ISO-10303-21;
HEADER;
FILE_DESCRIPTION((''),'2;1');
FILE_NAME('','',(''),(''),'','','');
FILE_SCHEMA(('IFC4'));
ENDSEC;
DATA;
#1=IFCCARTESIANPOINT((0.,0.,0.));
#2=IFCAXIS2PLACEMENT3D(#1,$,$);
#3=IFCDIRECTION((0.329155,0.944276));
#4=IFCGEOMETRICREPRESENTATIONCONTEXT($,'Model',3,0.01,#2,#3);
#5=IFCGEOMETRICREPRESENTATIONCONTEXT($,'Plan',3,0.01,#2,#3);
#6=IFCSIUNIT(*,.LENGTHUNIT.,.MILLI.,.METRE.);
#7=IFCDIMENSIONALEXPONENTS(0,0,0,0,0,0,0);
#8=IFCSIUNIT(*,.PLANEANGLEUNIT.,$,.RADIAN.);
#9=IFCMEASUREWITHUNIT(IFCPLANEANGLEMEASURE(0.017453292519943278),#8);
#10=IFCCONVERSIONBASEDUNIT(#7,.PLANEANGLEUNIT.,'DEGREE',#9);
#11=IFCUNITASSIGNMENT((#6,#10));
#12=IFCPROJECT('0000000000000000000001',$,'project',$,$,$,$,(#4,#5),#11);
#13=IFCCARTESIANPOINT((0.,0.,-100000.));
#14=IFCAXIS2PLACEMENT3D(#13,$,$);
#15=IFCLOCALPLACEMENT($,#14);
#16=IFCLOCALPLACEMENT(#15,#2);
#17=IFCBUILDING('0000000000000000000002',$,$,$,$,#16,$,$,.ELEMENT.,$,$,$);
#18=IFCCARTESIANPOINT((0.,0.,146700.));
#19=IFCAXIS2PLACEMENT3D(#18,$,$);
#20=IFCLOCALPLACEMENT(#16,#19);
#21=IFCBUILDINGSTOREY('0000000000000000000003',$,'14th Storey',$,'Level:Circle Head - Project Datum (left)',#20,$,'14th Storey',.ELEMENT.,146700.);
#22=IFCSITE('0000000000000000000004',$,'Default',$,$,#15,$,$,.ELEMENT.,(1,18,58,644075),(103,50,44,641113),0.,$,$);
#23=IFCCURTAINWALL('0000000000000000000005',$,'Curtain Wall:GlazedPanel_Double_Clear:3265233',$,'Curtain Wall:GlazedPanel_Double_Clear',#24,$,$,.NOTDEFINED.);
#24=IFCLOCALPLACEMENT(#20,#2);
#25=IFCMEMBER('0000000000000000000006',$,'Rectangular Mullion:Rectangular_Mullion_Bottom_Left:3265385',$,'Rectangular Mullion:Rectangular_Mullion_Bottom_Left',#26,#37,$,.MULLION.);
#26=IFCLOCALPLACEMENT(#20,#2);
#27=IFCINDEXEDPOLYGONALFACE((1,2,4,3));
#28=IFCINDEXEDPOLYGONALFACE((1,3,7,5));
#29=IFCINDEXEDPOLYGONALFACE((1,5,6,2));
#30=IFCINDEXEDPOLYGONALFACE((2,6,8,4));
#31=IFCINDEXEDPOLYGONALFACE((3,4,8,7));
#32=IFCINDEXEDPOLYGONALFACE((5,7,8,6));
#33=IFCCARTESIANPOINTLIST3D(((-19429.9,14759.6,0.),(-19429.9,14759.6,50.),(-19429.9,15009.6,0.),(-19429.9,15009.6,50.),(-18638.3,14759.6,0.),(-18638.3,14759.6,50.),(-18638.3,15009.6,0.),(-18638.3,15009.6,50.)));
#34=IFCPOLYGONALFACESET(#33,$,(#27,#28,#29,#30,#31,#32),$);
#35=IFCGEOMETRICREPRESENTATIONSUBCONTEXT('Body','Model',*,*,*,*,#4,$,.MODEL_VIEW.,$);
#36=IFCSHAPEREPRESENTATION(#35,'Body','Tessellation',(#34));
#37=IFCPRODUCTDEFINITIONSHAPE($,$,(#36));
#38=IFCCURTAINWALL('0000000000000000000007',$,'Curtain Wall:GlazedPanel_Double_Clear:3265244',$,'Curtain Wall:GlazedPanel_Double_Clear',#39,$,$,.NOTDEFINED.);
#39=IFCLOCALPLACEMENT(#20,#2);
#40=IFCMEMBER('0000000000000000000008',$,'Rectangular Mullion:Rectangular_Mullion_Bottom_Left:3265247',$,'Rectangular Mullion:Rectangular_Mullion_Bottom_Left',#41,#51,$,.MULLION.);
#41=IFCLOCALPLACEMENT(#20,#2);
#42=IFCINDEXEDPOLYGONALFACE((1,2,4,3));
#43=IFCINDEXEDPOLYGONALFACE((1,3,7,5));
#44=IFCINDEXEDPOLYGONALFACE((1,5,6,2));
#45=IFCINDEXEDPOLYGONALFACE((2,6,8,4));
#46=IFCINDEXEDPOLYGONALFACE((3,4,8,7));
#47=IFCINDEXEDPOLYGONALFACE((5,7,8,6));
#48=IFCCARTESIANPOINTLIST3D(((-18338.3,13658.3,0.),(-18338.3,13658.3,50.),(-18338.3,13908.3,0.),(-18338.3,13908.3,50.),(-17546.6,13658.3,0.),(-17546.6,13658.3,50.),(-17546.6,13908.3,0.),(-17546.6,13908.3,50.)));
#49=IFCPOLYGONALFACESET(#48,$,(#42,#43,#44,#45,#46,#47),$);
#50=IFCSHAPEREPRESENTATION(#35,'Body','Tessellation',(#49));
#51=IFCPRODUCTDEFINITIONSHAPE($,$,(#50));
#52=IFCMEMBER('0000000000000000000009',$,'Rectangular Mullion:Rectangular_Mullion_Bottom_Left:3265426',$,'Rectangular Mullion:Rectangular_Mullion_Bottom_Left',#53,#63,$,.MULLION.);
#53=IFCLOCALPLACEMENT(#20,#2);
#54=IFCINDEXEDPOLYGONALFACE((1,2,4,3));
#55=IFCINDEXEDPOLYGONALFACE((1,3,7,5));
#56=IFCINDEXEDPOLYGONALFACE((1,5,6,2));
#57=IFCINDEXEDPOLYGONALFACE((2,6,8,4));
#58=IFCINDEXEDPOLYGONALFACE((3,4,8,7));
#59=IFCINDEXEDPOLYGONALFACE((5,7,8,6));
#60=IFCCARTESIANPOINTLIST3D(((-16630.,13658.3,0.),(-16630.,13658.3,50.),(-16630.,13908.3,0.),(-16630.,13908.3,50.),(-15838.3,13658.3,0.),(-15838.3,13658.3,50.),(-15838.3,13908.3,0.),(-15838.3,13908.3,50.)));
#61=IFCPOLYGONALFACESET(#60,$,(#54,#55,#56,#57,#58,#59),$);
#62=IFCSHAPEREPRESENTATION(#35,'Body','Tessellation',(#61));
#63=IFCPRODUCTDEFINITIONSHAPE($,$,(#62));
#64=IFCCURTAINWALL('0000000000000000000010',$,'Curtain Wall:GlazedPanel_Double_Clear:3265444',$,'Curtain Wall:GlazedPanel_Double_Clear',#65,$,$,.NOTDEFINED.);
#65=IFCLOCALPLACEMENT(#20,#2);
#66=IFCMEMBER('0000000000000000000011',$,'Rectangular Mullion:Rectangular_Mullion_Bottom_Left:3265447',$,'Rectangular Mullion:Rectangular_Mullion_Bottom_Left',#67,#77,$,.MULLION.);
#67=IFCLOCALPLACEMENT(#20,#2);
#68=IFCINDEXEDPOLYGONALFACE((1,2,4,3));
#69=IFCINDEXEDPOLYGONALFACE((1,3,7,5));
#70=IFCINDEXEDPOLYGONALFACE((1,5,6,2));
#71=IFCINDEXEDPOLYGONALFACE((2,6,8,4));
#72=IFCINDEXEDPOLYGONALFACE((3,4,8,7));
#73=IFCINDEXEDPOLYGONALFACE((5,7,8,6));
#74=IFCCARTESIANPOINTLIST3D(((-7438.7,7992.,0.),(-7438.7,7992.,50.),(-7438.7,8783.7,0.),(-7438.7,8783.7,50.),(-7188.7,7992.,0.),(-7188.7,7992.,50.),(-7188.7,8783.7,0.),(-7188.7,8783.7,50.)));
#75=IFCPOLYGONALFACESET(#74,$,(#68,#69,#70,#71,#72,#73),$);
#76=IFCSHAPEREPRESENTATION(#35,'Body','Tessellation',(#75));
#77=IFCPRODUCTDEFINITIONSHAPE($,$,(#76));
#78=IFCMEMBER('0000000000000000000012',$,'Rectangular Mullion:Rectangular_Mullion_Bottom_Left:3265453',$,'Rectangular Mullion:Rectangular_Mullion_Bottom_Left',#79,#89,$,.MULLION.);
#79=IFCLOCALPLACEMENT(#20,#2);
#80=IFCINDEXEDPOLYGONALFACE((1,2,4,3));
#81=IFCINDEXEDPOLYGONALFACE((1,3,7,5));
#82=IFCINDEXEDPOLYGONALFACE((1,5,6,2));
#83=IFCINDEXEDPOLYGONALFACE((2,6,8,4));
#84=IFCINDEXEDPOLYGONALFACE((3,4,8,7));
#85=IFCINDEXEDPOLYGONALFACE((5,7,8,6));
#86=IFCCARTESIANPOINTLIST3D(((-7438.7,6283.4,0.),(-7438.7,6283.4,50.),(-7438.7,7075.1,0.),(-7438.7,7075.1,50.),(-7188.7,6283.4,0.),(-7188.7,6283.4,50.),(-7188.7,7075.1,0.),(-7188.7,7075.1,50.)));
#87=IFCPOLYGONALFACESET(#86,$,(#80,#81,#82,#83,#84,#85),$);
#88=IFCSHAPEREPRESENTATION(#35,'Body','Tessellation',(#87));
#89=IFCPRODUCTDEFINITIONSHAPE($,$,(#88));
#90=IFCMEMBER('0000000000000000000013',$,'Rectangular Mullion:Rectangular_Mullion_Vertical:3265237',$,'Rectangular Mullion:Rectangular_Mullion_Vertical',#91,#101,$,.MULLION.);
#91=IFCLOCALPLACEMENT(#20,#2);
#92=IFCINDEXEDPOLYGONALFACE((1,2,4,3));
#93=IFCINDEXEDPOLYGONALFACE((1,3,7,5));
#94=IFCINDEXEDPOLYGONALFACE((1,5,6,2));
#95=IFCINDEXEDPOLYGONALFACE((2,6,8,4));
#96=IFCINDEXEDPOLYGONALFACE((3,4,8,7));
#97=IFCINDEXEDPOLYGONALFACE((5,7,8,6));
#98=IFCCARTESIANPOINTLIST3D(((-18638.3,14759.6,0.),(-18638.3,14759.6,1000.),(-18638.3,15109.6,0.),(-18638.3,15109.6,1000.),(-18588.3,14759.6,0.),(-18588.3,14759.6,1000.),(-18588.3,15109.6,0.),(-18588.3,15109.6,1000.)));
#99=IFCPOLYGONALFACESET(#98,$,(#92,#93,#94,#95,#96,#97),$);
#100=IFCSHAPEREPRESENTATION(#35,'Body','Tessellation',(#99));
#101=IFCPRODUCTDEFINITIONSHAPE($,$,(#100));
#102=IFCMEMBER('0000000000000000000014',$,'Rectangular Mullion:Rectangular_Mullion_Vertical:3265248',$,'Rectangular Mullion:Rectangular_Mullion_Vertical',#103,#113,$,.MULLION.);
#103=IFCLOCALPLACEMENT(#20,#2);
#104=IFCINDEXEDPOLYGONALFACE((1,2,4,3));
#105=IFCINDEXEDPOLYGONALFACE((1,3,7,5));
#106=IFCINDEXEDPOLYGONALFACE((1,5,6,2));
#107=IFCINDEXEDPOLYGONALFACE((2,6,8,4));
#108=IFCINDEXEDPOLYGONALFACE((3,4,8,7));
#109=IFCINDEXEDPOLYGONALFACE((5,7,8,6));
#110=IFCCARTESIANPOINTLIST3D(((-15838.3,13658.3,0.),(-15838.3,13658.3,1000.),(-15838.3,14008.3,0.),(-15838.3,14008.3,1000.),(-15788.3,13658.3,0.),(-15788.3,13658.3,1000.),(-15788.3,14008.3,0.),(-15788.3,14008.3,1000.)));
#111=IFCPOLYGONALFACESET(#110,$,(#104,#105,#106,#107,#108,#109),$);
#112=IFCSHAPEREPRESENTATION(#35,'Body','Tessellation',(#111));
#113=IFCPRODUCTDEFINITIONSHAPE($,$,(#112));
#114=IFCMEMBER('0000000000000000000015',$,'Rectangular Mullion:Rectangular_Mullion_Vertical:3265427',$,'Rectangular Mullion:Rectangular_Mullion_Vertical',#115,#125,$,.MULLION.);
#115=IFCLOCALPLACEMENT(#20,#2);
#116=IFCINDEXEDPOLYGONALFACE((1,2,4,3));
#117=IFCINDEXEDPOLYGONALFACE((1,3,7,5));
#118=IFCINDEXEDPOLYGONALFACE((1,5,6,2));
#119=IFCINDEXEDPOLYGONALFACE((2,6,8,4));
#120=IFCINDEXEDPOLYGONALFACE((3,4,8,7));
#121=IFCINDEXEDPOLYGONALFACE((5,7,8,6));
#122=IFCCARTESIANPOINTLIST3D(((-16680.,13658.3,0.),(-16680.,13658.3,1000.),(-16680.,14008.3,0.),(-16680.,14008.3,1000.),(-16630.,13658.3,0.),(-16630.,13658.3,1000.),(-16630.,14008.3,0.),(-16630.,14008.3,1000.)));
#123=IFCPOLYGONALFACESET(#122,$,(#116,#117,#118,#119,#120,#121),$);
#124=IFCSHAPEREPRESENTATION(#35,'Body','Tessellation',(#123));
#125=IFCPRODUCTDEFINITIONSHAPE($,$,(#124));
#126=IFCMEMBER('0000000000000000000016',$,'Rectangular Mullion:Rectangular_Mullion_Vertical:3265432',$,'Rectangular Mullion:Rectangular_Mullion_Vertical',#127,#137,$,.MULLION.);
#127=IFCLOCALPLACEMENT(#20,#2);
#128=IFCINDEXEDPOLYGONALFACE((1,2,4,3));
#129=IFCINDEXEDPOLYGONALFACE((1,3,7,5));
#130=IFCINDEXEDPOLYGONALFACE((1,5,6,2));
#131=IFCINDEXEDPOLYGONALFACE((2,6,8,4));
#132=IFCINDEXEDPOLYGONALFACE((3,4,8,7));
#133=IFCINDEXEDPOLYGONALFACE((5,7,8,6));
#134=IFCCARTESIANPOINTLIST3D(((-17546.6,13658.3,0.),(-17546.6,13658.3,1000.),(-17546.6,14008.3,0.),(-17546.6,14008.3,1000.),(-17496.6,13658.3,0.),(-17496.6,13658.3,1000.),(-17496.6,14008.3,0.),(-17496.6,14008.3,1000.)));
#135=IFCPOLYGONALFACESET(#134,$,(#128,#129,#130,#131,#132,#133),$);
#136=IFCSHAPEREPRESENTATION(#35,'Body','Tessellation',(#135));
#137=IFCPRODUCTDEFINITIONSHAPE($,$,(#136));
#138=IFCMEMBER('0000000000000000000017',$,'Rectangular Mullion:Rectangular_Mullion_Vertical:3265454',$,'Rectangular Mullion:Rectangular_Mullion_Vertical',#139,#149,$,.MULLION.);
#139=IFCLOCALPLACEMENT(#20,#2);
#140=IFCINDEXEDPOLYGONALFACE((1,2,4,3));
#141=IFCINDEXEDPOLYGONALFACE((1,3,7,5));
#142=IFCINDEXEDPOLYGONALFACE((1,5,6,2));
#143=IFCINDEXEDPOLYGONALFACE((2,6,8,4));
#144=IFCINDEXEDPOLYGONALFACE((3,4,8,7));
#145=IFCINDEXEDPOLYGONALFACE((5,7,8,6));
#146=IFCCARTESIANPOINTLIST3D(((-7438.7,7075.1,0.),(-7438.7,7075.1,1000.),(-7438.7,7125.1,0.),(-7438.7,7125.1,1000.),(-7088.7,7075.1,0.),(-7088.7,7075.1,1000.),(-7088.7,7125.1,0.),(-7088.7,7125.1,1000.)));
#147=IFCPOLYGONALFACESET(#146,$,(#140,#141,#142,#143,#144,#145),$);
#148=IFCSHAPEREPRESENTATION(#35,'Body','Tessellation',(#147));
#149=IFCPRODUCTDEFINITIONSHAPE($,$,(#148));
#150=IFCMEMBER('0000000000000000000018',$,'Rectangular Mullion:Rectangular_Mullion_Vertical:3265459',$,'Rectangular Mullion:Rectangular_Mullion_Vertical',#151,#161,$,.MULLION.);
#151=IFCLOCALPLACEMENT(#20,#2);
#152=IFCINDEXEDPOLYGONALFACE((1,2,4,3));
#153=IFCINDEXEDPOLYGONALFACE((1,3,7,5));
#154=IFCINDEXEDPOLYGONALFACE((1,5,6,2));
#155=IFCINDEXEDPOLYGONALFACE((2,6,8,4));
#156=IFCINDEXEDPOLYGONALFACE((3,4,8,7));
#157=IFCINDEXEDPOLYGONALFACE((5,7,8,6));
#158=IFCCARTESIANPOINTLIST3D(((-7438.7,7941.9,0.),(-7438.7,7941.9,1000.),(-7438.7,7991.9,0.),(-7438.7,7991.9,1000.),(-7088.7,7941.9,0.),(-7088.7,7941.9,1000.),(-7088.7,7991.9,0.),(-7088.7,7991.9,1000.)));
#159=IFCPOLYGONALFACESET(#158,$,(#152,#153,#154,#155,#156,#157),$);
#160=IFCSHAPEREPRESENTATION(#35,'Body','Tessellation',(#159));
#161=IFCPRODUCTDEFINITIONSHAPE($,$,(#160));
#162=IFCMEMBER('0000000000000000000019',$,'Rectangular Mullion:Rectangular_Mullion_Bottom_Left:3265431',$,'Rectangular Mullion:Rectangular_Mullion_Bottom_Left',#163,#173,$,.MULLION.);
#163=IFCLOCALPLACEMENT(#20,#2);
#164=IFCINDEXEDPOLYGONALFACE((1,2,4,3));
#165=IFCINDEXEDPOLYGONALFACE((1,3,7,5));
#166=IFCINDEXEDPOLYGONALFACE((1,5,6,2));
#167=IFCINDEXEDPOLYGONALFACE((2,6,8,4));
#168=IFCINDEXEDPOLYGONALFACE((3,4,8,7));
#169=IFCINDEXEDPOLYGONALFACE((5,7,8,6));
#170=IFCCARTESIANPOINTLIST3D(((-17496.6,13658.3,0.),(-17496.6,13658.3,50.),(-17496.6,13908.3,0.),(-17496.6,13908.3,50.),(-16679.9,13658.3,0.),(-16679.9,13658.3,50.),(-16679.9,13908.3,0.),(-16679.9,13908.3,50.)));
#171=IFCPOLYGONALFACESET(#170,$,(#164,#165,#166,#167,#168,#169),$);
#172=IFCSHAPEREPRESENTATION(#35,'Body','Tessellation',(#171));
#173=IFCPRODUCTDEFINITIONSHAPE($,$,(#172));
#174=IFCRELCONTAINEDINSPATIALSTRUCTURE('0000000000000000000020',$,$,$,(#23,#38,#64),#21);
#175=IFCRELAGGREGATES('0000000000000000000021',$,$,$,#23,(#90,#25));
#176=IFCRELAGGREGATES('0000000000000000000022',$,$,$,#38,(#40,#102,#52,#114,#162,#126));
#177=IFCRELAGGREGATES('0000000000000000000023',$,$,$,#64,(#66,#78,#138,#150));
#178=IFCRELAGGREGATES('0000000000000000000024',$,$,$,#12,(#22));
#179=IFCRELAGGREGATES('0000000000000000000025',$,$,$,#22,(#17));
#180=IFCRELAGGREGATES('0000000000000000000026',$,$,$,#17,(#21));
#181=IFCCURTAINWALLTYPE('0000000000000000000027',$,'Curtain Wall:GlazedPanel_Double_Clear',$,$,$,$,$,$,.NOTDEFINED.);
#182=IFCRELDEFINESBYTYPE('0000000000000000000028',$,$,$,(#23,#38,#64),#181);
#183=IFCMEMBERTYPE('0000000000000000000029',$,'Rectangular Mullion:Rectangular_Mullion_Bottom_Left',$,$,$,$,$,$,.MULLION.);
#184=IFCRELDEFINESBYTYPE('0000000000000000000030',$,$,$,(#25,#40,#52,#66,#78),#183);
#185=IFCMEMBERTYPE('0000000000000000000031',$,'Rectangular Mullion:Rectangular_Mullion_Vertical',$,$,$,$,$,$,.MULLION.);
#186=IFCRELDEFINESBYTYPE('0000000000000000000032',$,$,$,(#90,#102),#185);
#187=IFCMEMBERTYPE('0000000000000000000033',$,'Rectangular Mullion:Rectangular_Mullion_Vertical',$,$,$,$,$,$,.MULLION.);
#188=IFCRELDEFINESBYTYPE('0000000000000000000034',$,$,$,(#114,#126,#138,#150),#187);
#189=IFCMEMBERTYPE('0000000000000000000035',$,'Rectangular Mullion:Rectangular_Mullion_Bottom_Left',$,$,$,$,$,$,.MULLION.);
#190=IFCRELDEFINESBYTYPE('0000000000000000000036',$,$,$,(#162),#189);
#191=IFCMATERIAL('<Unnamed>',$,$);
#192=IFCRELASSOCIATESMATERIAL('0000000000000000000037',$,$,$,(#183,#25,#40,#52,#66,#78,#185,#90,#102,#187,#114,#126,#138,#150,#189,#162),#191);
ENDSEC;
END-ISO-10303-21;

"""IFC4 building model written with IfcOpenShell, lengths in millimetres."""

from ifc_helpers import new_model, entity, si_unit, converted_unit, direction, frame, origin, place, context, subcontext, project, spatial, indexed_curve, outline, extrude, source, transform, mapped, material, type_object, type_shapes, element, aggregate, save


model = new_model("IFC4")

# Units and contexts
model_context = context("Model", 3, precision=0.01, world=origin(), true_north=direction((0.329155, 0.944276)))
plan_context = context("Plan", 3, precision=0.01, world=origin(), true_north=direction((0.329155, 0.944276)))
body_context = subcontext(model_context, "Body", "Model", "MODEL_VIEW")
ifc_project = project(units=[si_unit("LENGTHUNIT", "METRE", prefix="MILLI"), converted_unit("PLANEANGLEUNIT", "DEGREE", entity("IfcPlaneAngleMeasure", 0.017453292519943278), si_unit("PLANEANGLEUNIT", "RADIAN"), dimensions=[0, 0, 0, 0, 0, 0, 0])], contexts=[model_context, plan_context])

# Site, building, storey
site_placement = place(None, frame((0.0, 0.0, -100000.0)))
site = spatial("IfcSite", under=ifc_project, at=site_placement, Name="Default", CompositionType="ELEMENT", RefLatitude=(1, 18, 58, 644075), RefLongitude=(103, 50, 44, 641113), RefElevation=0.0)
building_placement = place(site_placement, origin())
building = spatial("IfcBuilding", under=site, at=building_placement, CompositionType="ELEMENT")
storey_placement = place(building_placement, frame((0.0, 0.0, 146700.0)))
storey = spatial("IfcBuildingStorey", under=building, at=storey_placement, Name="14th Storey", ObjectType="Level:Circle Head - Project Datum (left)", LongName="14th Storey", CompositionType="ELEMENT", Elevation=146700.0)

# Curtain wall, member
curtain_wall_type = type_object("IfcCurtainWallType", Name="Curtain Wall:GlazedPanel_Double_Clear", PredefinedType="NOTDEFINED")
curtain_wall_1_placement = place(storey_placement, frame((0.0, 0.0, -146700.0)))
curtain_wall_1 = element("IfcCurtainWall", 1, at=curtain_wall_1_placement, inside=storey, type_object=curtain_wall_type, Name="Curtain Wall:GlazedPanel_Double_Clear:3265233", ObjectType="Curtain Wall:GlazedPanel_Double_Clear", PredefinedType="NOTDEFINED")
ifc_material_1 = material(Name="<Unnamed>")
member_type_1 = type_object("IfcMemberType", Name="Rectangular Mullion:Rectangular_Mullion_Bottom_Left", PredefinedType="MULLION", material=ifc_material_1)
shared_shape_1 = source(origin(), body_context, "Body", "SweptSolid", [
    extrude(outline(indexed_curve([(-25.0, -125.0), (25.0, -125.0), (25.0, 125.0), (-25.0, 125.0), (-25.0, -125.0)], self_intersect=False)), frame((-25.0, 0.0, -791.7), z_axis=(0.0, 0.0, 1.0), x_axis=(-1.0, 0.0, 0.0)), (0.0, 0.0, 1.0), 791.7),
])
type_shapes(member_type_1, [shared_shape_1])
member_1_placement = place(curtain_wall_1_placement, frame((-19429.9, 14884.6, 146700.0), z_axis=(-1.0, 0.0, 0.0), x_axis=(0.0, 0.0, -1.0)))
member_1 = element("IfcMember", 2, at=member_1_placement, type_object=member_type_1, material=ifc_material_1, Name="Rectangular Mullion:Rectangular_Mullion_Bottom_Left:3265385", ObjectType="Rectangular Mullion:Rectangular_Mullion_Bottom_Left", PredefinedType="MULLION", context=body_context, shape_type="MappedRepresentation", body=[
    mapped(shared_shape_1, transform((0.0, 0.0, 0.0), scale=1.0)),
])

# Curtain walls, members
curtain_wall_2_placement = place(storey_placement, frame((0.0, 0.0, -146700.0)))
curtain_wall_2 = element("IfcCurtainWall", 3, at=curtain_wall_2_placement, inside=storey, type_object=curtain_wall_type, Name="Curtain Wall:GlazedPanel_Double_Clear:3265244", ObjectType="Curtain Wall:GlazedPanel_Double_Clear", PredefinedType="NOTDEFINED")
member_2_placement = place(curtain_wall_2_placement, frame((-18338.3, 13783.3, 146700.0), z_axis=(-1.0, 0.0, 0.0), x_axis=(0.0, 0.0, -1.0)))
member_2 = element("IfcMember", 4, at=member_2_placement, type_object=member_type_1, material=ifc_material_1, Name="Rectangular Mullion:Rectangular_Mullion_Bottom_Left:3265247", ObjectType="Rectangular Mullion:Rectangular_Mullion_Bottom_Left", PredefinedType="MULLION", context=body_context, shape_type="MappedRepresentation", body=[
    mapped(shared_shape_1, transform((0.0, 0.0, 0.0), scale=1.0)),
])
member_3_placement = place(curtain_wall_2_placement, frame((-16630.0, 13783.3, 146700.0), z_axis=(-1.0, 0.0, 0.0), x_axis=(0.0, 0.0, -1.0)))
member_3 = element("IfcMember", 5, at=member_3_placement, type_object=member_type_1, material=ifc_material_1, Name="Rectangular Mullion:Rectangular_Mullion_Bottom_Left:3265426", ObjectType="Rectangular Mullion:Rectangular_Mullion_Bottom_Left", PredefinedType="MULLION", context=body_context, shape_type="MappedRepresentation", body=[
    mapped(shared_shape_1, transform((0.0, 0.0, 0.0), scale=1.0)),
])
curtain_wall_3_placement = place(storey_placement, frame((0.0, 0.0, -146700.0)))
curtain_wall_3 = element("IfcCurtainWall", 6, at=curtain_wall_3_placement, inside=storey, type_object=curtain_wall_type, Name="Curtain Wall:GlazedPanel_Double_Clear:3265444", ObjectType="Curtain Wall:GlazedPanel_Double_Clear", PredefinedType="NOTDEFINED")
member_4_placement = place(curtain_wall_3_placement, frame((-7313.7, 8783.7, 146700.0), z_axis=(0.0, 1.0, 0.0), x_axis=(0.0, 0.0, -1.0)))
member_4 = element("IfcMember", 7, at=member_4_placement, type_object=member_type_1, material=ifc_material_1, Name="Rectangular Mullion:Rectangular_Mullion_Bottom_Left:3265447", ObjectType="Rectangular Mullion:Rectangular_Mullion_Bottom_Left", PredefinedType="MULLION", context=body_context, shape_type="MappedRepresentation", body=[
    mapped(shared_shape_1, transform((0.0, 0.0, 0.0), scale=1.0)),
])
member_5_placement = place(curtain_wall_3_placement, frame((-7313.7, 7075.1, 146700.0), z_axis=(0.0, 1.0, 0.0), x_axis=(0.0, 0.0, -1.0)))
member_5 = element("IfcMember", 8, at=member_5_placement, type_object=member_type_1, material=ifc_material_1, Name="Rectangular Mullion:Rectangular_Mullion_Bottom_Left:3265453", ObjectType="Rectangular Mullion:Rectangular_Mullion_Bottom_Left", PredefinedType="MULLION", context=body_context, shape_type="MappedRepresentation", body=[
    mapped(shared_shape_1, transform((0.0, 0.0, 0.0), scale=1.0)),
])

# Members
member_type_2 = type_object("IfcMemberType", Name="Rectangular Mullion:Rectangular_Mullion_Vertical", PredefinedType="MULLION", material=ifc_material_1)
shared_shape_2 = source(origin(), body_context, "Body", "SweptSolid", [
    extrude(outline(indexed_curve([(-25.0, -175.0), (25.0, -175.0), (25.0, 175.0), (-25.0, 175.0), (-25.0, -175.0)], self_intersect=False)), frame((-25.0, -50.0, -1000.0), z_axis=(0.0, 0.0, 1.0), x_axis=(-1.0, 0.0, 0.0)), (0.0, 0.0, 1.0), 1000.0),
])
type_shapes(member_type_2, [shared_shape_2])
member_6_placement = place(curtain_wall_1_placement, frame((-18588.3, 14884.6, 146700.0), z_axis=(0.0, 0.0, -1.0), x_axis=(1.0, 0.0, 0.0)))
member_6 = element("IfcMember", 9, at=member_6_placement, type_object=member_type_2, material=ifc_material_1, Name="Rectangular Mullion:Rectangular_Mullion_Vertical:3265237", ObjectType="Rectangular Mullion:Rectangular_Mullion_Vertical", PredefinedType="MULLION", context=body_context, shape_type="MappedRepresentation", body=[
    mapped(shared_shape_2, transform((0.0, 0.0, 0.0), scale=1.0)),
])
aggregate(curtain_wall_1, [member_6, member_1])
member_7_placement = place(curtain_wall_2_placement, frame((-15788.3, 13783.3, 146700.0), z_axis=(0.0, 0.0, -1.0), x_axis=(1.0, 0.0, 0.0)))
member_7 = element("IfcMember", 10, at=member_7_placement, type_object=member_type_2, material=ifc_material_1, Name="Rectangular Mullion:Rectangular_Mullion_Vertical:3265248", ObjectType="Rectangular Mullion:Rectangular_Mullion_Vertical", PredefinedType="MULLION", context=body_context, shape_type="MappedRepresentation", body=[
    mapped(shared_shape_2, transform((0.0, 0.0, 0.0), scale=1.0)),
])
member_type_3 = type_object("IfcMemberType", Name="Rectangular Mullion:Rectangular_Mullion_Vertical", PredefinedType="MULLION", material=ifc_material_1)
shared_shape_3 = source(origin(), body_context, "Body", "SweptSolid", [
    extrude(outline(indexed_curve([(-25.0, -175.0), (25.0, -175.0), (25.0, 175.0), (-25.0, 175.0), (-25.0, -175.0)], self_intersect=False)), frame((0.0, -50.0, -1000.0), z_axis=(0.0, 0.0, 1.0), x_axis=(-1.0, 0.0, 0.0)), (0.0, 0.0, 1.0), 1000.0),
])
type_shapes(member_type_3, [shared_shape_3])
member_8_placement = place(curtain_wall_2_placement, frame((-16655.0, 13783.3, 146700.0), z_axis=(0.0, 0.0, -1.0), x_axis=(1.0, 0.0, 0.0)))
member_8 = element("IfcMember", 11, at=member_8_placement, type_object=member_type_3, material=ifc_material_1, Name="Rectangular Mullion:Rectangular_Mullion_Vertical:3265427", ObjectType="Rectangular Mullion:Rectangular_Mullion_Vertical", PredefinedType="MULLION", context=body_context, shape_type="MappedRepresentation", body=[
    mapped(shared_shape_3, transform((0.0, 0.0, 0.0), scale=1.0)),
])
member_9_placement = place(curtain_wall_2_placement, frame((-17521.6, 13783.3, 146700.0), z_axis=(0.0, 0.0, -1.0), x_axis=(1.0, 0.0, 0.0)))
member_9 = element("IfcMember", 12, at=member_9_placement, type_object=member_type_3, material=ifc_material_1, Name="Rectangular Mullion:Rectangular_Mullion_Vertical:3265432", ObjectType="Rectangular Mullion:Rectangular_Mullion_Vertical", PredefinedType="MULLION", context=body_context, shape_type="MappedRepresentation", body=[
    mapped(shared_shape_3, transform((0.0, 0.0, 0.0), scale=1.0)),
])
member_10_placement = place(curtain_wall_3_placement, frame((-7313.7, 7100.1, 146700.0), z_axis=(0.0, 0.0, -1.0), x_axis=(0.0, -1.0, 0.0)))
member_10 = element("IfcMember", 13, at=member_10_placement, type_object=member_type_3, material=ifc_material_1, Name="Rectangular Mullion:Rectangular_Mullion_Vertical:3265454", ObjectType="Rectangular Mullion:Rectangular_Mullion_Vertical", PredefinedType="MULLION", context=body_context, shape_type="MappedRepresentation", body=[
    mapped(shared_shape_3, transform((0.0, 0.0, 0.0), scale=1.0)),
])
member_11_placement = place(curtain_wall_3_placement, frame((-7313.7, 7966.9, 146700.0), z_axis=(0.0, 0.0, -1.0), x_axis=(0.0, -1.0, 0.0)))
member_11 = element("IfcMember", 14, at=member_11_placement, type_object=member_type_3, material=ifc_material_1, Name="Rectangular Mullion:Rectangular_Mullion_Vertical:3265459", ObjectType="Rectangular Mullion:Rectangular_Mullion_Vertical", PredefinedType="MULLION", context=body_context, shape_type="MappedRepresentation", body=[
    mapped(shared_shape_3, transform((0.0, 0.0, 0.0), scale=1.0)),
])
member_type_4 = type_object("IfcMemberType", Name="Rectangular Mullion:Rectangular_Mullion_Bottom_Left", PredefinedType="MULLION", material=ifc_material_1)
shared_shape_4 = source(origin(), body_context, "Body", "SweptSolid", [
    extrude(outline(indexed_curve([(-25.0, -125.0), (25.0, -125.0), (25.0, 125.0), (-25.0, 125.0), (-25.0, -125.0)], self_intersect=False)), frame((-25.0, 0.0, -816.7), z_axis=(0.0, 0.0, 1.0), x_axis=(-1.0, 0.0, 0.0)), (0.0, 0.0, 1.0), 816.7),
])
type_shapes(member_type_4, [shared_shape_4])
member_12_placement = place(curtain_wall_2_placement, frame((-17496.6, 13783.3, 146700.0), z_axis=(-1.0, 0.0, 0.0), x_axis=(0.0, 0.0, -1.0)))
member_12 = element("IfcMember", 15, at=member_12_placement, type_object=member_type_4, material=ifc_material_1, Name="Rectangular Mullion:Rectangular_Mullion_Bottom_Left:3265431", ObjectType="Rectangular Mullion:Rectangular_Mullion_Bottom_Left", PredefinedType="MULLION", context=body_context, shape_type="MappedRepresentation", body=[
    mapped(shared_shape_4, transform((0.0, 0.0, 0.0), scale=1.0)),
])
aggregate(curtain_wall_2, [member_2, member_7, member_3, member_8, member_12, member_9])
aggregate(curtain_wall_3, [member_4, member_5, member_10, member_11])

save(model, "model.ifc")
